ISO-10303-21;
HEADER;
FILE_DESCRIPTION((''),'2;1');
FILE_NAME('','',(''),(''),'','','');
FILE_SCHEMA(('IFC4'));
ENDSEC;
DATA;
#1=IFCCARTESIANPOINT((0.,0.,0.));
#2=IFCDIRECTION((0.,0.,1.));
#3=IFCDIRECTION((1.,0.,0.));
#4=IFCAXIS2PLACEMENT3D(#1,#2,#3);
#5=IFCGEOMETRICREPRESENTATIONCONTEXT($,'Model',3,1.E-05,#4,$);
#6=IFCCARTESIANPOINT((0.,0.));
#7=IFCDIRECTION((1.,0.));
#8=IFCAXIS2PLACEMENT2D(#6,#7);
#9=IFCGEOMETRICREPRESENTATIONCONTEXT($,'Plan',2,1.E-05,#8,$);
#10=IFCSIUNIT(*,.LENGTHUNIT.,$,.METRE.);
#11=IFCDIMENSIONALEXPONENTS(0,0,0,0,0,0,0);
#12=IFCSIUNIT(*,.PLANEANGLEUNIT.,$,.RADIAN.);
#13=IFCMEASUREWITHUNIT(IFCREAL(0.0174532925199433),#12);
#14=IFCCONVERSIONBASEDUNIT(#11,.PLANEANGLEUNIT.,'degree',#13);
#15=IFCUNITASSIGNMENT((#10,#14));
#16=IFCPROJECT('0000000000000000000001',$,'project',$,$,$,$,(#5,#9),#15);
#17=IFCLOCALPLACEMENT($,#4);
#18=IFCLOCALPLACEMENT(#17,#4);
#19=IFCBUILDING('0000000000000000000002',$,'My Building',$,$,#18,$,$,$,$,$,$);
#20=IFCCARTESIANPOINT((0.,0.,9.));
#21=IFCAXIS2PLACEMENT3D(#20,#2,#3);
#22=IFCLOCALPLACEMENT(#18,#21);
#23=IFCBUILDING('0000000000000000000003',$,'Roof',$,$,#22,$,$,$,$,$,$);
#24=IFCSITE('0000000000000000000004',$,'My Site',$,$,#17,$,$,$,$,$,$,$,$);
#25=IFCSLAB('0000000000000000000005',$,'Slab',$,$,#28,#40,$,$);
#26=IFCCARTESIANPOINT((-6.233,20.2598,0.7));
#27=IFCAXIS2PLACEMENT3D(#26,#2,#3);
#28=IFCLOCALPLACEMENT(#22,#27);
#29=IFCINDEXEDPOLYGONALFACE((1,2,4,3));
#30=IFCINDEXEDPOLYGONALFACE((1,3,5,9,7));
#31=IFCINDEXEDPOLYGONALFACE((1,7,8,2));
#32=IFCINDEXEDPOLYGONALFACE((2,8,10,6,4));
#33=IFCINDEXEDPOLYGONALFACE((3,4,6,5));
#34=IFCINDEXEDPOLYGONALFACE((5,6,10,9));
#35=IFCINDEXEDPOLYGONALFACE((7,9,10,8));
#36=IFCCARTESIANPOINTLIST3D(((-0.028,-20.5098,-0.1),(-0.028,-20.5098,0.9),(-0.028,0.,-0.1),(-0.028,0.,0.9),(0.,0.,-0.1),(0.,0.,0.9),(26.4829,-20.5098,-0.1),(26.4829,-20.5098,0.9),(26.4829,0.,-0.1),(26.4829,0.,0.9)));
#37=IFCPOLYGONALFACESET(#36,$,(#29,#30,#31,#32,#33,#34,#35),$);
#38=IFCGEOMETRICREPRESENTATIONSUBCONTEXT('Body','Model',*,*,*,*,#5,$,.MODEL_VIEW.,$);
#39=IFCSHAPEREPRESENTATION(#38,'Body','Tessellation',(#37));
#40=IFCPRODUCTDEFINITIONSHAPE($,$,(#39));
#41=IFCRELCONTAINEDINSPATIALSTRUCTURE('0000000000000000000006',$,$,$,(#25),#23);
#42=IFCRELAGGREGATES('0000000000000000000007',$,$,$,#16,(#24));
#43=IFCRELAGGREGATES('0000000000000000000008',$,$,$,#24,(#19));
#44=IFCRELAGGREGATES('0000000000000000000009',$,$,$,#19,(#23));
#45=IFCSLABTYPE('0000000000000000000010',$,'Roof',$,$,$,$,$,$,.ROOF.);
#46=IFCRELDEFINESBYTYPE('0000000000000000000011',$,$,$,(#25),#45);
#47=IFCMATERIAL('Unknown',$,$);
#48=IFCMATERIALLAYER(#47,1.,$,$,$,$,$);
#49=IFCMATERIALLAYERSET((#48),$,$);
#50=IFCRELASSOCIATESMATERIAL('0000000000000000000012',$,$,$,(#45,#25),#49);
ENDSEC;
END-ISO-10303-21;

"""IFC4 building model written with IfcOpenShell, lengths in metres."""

from ifc_helpers import new_model, entity, si_unit, converted_unit, frame, origin_with_axes, origin_2d_with_axis, place, context, subcontext, project, spatial, indexed_curve, outline, extrude, material, layer, layer_set, layer_usage, type_object, element, save


model = new_model("IFC4")

# Units and contexts
model_context = context("Model", 3, precision=1e-05, world=origin_with_axes())
plan_context = context("Plan", 2, precision=1e-05, world=origin_2d_with_axis())
body_context = subcontext(model_context, "Body", "Model", "MODEL_VIEW")
ifc_project = project(units=[si_unit("LENGTHUNIT", "METRE"), converted_unit("PLANEANGLEUNIT", "degree", entity("IfcReal", 0.0174532925199433), si_unit("PLANEANGLEUNIT", "RADIAN"), dimensions=[0, 0, 0, 0, 0, 0, 0])], contexts=[model_context, plan_context])

# Site, buildings
site_placement = place(None, origin_with_axes())
site = spatial("IfcSite", under=ifc_project, at=site_placement, Name="My Site")
building_1_placement = place(site_placement, origin_with_axes())
building_1 = spatial("IfcBuilding", under=site, at=building_1_placement, Name="My Building")
building_2_placement = place(building_1_placement, frame((0.0, 0.0, 9.0), z_axis=(0.0, 0.0, 1.0), x_axis=(1.0, 0.0, 0.0)))
building_2 = spatial("IfcBuilding", under=building_1, at=building_2_placement, Name="Roof")

# Slab
ifc_material = material(Name="Unknown")
ifc_layer = layer(ifc_material, 1.0)
ifc_layer_set = layer_set([ifc_layer])
ifc_layer_usage = layer_usage(ifc_layer_set, "AXIS3", "POSITIVE", -0.1)
slab_type = type_object("IfcSlabType", Name="Roof", PredefinedType="ROOF", material=ifc_layer_set)
slab_placement = place(building_2_placement, frame((-6.233, 20.2598, 0.7), z_axis=(0.0, 0.0, 1.0), x_axis=(1.0, 0.0, 0.0)))
element("IfcSlab", 1, at=slab_placement, inside=building_2, type_object=slab_type, material=ifc_layer_usage, Name="Slab", context=body_context, shape_type="SweptSolid", body=[
    extrude(outline(indexed_curve([(0.0, 0.0), (26.4829, 0.0), (26.4829, -20.5098), (-0.028, -20.5098), (-0.028, 0.0), (0.0, 0.0)])), frame((0.0, 0.0, -0.1), z_axis=(0.0, 0.0, 1.0), x_axis=(1.0, 0.0, 0.0)), (0.0, 0.0, 1.0), 1.0),
])

save(model, "model.ifc")
